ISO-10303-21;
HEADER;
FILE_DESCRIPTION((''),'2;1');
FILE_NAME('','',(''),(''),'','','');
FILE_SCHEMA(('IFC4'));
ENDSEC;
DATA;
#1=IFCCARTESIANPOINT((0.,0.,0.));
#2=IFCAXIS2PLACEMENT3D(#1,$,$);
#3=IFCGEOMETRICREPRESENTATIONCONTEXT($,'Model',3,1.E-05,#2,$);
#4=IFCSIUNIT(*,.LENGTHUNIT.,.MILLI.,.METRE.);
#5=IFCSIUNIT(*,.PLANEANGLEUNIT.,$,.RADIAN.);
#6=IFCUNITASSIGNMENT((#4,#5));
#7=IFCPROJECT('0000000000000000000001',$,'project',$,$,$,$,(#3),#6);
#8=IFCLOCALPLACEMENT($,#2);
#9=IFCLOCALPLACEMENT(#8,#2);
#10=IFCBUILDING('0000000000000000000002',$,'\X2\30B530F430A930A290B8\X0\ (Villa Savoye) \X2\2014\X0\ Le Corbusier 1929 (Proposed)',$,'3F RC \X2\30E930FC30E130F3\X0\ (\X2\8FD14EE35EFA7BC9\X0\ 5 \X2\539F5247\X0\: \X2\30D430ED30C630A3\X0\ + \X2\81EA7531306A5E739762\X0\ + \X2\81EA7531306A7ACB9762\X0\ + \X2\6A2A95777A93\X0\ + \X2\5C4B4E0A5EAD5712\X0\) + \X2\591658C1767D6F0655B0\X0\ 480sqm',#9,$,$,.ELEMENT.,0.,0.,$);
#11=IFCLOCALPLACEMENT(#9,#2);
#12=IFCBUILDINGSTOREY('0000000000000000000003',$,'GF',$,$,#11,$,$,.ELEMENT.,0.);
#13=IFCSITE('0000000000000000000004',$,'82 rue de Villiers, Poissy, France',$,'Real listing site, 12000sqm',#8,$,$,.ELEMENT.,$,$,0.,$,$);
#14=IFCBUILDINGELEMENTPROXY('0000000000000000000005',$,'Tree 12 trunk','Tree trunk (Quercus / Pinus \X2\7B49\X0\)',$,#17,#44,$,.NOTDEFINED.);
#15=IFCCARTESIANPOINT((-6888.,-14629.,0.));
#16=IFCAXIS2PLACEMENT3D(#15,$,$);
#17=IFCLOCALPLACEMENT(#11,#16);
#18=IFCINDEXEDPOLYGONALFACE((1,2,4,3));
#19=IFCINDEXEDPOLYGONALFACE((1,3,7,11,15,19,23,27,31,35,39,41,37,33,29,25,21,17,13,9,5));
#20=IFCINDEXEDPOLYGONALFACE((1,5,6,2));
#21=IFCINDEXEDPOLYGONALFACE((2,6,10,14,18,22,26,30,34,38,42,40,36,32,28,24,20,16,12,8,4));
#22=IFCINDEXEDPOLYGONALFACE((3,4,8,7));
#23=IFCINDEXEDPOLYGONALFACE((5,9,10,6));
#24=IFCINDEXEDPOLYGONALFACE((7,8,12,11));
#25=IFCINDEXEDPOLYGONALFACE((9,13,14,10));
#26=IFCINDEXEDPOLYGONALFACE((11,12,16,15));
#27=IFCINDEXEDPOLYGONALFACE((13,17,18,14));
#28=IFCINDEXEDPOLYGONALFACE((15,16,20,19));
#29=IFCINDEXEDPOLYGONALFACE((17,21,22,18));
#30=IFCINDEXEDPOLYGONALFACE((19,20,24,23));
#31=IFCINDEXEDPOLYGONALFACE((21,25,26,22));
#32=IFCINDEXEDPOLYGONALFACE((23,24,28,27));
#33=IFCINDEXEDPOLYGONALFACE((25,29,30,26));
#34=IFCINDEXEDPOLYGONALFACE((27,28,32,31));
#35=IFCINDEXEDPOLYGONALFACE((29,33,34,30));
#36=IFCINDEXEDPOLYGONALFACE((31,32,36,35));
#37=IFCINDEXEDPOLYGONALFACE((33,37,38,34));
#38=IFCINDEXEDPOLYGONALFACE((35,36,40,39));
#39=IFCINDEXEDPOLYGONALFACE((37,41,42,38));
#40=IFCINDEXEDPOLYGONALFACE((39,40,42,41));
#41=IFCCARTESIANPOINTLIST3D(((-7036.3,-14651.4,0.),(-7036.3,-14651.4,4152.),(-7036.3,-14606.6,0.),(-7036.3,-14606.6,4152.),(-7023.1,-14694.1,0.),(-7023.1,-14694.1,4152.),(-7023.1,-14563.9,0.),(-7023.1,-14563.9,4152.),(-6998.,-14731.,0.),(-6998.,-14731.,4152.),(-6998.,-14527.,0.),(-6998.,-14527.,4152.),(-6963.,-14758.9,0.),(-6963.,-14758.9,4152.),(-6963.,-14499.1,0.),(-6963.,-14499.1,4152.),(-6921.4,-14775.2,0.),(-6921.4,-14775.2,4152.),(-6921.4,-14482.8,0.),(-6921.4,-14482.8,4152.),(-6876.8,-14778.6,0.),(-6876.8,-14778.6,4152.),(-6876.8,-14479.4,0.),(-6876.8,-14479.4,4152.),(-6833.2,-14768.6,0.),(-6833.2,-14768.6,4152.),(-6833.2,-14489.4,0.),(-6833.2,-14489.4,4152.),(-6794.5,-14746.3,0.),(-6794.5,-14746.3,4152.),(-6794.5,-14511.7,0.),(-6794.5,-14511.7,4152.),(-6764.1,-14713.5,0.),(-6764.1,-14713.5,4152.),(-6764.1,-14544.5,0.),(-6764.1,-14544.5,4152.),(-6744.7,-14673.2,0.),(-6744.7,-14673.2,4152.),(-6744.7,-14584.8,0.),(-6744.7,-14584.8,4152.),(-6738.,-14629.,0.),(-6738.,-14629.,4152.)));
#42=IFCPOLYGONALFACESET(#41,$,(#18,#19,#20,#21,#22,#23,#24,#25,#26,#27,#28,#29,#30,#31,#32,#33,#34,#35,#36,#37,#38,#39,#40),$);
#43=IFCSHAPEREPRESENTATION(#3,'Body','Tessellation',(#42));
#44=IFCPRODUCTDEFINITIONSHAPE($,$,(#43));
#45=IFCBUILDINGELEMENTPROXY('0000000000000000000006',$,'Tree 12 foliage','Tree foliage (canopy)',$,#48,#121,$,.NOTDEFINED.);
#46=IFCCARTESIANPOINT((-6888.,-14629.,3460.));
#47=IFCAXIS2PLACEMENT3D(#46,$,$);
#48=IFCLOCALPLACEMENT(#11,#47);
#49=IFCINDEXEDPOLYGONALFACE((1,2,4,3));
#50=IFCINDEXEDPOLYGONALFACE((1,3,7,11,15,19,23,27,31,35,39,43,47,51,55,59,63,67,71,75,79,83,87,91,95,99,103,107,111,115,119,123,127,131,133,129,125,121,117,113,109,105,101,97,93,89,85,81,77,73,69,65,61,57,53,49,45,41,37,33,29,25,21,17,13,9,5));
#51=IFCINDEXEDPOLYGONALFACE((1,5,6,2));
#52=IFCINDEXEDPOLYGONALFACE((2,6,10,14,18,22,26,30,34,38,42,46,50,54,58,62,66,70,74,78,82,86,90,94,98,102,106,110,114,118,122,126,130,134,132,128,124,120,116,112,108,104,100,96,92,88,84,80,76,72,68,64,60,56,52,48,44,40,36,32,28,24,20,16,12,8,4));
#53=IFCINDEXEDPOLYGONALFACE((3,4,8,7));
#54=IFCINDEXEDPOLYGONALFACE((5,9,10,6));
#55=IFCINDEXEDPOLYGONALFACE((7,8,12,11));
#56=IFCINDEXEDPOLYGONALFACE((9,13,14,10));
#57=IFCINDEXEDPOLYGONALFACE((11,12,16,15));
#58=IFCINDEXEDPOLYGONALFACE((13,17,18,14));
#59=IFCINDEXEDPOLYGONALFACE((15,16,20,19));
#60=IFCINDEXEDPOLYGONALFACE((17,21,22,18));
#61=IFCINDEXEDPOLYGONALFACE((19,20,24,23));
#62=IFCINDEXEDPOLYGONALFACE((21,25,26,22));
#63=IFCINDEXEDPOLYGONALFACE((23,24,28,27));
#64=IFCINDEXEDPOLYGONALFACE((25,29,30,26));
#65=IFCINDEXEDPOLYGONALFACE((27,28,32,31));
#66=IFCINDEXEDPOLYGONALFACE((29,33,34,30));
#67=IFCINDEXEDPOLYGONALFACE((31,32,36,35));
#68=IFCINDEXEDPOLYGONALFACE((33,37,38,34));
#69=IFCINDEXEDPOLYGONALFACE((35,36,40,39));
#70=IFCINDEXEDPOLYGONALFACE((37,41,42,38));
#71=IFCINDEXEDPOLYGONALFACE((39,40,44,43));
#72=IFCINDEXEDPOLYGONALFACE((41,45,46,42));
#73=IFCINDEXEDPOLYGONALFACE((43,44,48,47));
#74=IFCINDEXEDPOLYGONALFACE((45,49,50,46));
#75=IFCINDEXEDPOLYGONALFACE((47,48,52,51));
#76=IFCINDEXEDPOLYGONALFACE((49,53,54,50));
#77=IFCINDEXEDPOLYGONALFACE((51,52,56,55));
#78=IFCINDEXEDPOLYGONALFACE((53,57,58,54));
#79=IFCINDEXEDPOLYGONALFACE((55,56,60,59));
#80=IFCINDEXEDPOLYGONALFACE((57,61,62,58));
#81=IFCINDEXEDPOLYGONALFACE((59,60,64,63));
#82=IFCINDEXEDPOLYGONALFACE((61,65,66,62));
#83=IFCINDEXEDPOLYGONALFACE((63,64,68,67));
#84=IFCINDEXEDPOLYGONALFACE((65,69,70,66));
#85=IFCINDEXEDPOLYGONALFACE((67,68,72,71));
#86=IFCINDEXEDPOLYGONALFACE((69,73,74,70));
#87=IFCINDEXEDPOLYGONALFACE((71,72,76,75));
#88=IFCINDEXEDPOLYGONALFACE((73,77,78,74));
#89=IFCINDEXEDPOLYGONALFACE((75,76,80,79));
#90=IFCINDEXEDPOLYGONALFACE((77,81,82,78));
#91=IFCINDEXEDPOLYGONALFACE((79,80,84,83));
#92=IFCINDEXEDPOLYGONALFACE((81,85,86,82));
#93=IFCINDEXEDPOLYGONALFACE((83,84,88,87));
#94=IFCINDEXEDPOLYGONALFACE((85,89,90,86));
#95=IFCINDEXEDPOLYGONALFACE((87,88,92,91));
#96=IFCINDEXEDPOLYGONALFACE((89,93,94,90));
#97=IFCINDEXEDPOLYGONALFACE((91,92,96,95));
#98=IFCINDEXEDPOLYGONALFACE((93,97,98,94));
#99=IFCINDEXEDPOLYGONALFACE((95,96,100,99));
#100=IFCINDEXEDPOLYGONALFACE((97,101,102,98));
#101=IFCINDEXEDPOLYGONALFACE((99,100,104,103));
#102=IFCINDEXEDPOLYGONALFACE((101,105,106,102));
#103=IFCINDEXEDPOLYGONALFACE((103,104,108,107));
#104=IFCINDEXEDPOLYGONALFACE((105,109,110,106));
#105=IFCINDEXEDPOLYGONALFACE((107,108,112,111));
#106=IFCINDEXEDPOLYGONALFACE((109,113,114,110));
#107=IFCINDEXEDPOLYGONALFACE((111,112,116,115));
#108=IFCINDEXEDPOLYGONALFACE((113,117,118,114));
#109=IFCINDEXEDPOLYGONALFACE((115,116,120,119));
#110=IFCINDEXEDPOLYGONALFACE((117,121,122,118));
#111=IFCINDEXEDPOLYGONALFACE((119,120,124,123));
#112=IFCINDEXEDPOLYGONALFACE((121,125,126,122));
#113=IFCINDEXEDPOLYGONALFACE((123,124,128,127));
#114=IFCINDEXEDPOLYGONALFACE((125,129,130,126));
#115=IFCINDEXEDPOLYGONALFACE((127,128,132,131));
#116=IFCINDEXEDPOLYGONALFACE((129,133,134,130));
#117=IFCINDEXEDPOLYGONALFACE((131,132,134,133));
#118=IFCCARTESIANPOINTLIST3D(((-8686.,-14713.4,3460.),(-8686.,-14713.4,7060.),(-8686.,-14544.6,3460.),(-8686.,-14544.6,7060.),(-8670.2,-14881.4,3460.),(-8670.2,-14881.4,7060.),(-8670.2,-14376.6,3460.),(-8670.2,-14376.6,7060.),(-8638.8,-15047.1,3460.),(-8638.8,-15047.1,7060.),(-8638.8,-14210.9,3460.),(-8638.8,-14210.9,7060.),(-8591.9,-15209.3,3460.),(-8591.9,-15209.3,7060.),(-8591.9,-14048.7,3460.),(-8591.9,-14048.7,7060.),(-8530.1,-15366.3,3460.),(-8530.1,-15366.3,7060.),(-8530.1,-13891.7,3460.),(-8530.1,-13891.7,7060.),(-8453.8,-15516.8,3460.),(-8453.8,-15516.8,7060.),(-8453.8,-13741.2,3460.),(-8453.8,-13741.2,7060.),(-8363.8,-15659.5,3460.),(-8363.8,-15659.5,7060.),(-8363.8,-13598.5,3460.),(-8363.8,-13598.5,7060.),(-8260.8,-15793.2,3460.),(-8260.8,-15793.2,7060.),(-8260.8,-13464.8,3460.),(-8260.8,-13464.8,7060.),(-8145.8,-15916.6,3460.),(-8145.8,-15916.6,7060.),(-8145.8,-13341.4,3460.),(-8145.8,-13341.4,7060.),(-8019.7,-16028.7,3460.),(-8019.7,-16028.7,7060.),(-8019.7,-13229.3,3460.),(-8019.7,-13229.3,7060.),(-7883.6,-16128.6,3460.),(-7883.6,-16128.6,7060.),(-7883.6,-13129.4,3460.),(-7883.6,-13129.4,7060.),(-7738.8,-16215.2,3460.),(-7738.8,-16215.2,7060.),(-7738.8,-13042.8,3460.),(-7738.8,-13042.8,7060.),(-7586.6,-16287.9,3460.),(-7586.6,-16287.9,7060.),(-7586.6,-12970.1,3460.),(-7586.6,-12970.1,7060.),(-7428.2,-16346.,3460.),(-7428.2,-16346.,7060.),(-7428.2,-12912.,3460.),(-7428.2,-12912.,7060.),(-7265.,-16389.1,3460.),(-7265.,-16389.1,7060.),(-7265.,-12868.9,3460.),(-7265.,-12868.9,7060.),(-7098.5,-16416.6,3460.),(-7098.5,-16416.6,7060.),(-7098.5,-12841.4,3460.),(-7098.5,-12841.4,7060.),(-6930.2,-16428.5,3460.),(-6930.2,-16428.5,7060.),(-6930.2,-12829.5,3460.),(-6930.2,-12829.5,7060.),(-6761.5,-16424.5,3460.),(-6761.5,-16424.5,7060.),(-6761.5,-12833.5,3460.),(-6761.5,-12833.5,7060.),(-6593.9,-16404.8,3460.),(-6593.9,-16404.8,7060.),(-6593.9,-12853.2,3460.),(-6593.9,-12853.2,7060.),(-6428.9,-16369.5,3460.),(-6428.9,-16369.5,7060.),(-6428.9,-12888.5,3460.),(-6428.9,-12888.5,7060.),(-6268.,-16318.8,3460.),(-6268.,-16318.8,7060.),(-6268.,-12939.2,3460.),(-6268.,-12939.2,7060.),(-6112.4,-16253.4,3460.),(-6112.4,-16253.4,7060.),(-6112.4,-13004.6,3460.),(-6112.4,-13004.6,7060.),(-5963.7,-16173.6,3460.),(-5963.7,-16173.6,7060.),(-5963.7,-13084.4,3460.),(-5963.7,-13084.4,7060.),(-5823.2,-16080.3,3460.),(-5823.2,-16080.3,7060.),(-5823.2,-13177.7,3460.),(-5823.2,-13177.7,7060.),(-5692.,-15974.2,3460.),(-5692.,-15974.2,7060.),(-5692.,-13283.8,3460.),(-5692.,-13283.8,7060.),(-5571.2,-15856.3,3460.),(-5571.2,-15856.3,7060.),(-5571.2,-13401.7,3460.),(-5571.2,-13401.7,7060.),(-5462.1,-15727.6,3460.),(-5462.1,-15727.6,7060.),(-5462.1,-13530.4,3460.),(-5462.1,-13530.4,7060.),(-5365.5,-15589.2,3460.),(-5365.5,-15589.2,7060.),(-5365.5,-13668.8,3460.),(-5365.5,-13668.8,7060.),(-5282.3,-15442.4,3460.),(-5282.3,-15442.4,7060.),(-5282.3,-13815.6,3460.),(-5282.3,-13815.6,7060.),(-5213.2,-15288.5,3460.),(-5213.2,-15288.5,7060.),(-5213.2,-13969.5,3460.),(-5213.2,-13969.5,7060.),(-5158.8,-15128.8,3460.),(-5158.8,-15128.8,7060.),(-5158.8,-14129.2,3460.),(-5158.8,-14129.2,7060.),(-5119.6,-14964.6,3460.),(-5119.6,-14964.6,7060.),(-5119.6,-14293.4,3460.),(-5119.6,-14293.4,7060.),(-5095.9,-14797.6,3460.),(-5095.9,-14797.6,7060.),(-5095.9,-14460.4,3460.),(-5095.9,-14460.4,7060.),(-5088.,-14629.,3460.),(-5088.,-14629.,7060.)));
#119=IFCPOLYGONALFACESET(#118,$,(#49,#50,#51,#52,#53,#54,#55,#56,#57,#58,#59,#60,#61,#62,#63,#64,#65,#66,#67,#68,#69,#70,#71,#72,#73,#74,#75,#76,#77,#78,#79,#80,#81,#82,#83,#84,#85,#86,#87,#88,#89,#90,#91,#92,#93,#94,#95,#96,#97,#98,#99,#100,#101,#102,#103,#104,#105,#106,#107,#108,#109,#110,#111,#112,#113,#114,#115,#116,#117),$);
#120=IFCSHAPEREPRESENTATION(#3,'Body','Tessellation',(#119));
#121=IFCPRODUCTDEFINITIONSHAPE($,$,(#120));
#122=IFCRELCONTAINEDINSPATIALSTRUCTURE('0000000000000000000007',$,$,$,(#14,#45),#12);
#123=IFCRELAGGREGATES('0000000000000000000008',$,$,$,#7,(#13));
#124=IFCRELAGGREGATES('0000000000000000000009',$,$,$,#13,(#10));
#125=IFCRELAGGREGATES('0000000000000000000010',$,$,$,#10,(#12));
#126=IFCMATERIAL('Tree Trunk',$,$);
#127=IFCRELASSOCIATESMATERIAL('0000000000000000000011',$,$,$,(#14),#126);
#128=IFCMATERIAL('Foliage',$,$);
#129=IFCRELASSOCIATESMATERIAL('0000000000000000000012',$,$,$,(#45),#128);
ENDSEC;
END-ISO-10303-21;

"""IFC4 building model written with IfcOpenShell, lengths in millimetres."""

from ifc_helpers import new_model, si_unit, frame, origin, origin_2d, place, context, project, spatial, circle, extrude, material, element, save


model = new_model("IFC4")

# Units and contexts
model_context = context("Model", 3, precision=1e-05, world=origin())
ifc_project = project(units=[si_unit("LENGTHUNIT", "METRE", prefix="MILLI"), si_unit("PLANEANGLEUNIT", "RADIAN")], contexts=[model_context])

# Site, building, storey
site_placement = place(None, origin())
site = spatial("IfcSite", under=ifc_project, at=site_placement, Name="82 rue de Villiers, Poissy, France", ObjectType="Real listing site, 12000sqm", CompositionType="ELEMENT", RefElevation=0.0)
building_placement = place(site_placement, origin())
building = spatial("IfcBuilding", under=site, at=building_placement, Name="サヴォア邸 (Villa Savoye) — Le Corbusier 1929 (Proposed)", ObjectType="3F RC ラーメン (近代建築 5 原則: ピロティ + 自由な平面 + 自由な立面 + 横長窓 + 屋上庭園) + 外壁白漆喰 480sqm", CompositionType="ELEMENT", ElevationOfRefHeight=0.0, ElevationOfTerrain=0.0)
storey_placement = place(building_placement, origin())
storey = spatial("IfcBuildingStorey", under=building, at=storey_placement, Name="GF", CompositionType="ELEMENT", Elevation=0.0)

# Building element proxies
ifc_material_1 = material(Name="Tree Trunk")
ifc_material_2 = material(Name="Foliage")
proxy_1_placement = place(storey_placement, frame((-6888.0, -14629.0, 0.0)))
element("IfcBuildingElementProxy", 1, at=proxy_1_placement, inside=storey, material=ifc_material_1, Name="Tree 12 trunk", Description="Tree trunk (Quercus / Pinus 等)", PredefinedType="NOTDEFINED", context=model_context, shape_type="SweptSolid", body=[
    extrude(circle(Radius=150.0, at=origin_2d()), frame((-6888.0, -14629.0, 0.0)), (0.0, 0.0, 1.0), 4152.0),
])
proxy_2_placement = place(storey_placement, frame((-6888.0, -14629.0, 3460.0)))
element("IfcBuildingElementProxy", 2, at=proxy_2_placement, inside=storey, material=ifc_material_2, Name="Tree 12 foliage", Description="Tree foliage (canopy)", PredefinedType="NOTDEFINED", context=model_context, shape_type="SweptSolid", body=[
    extrude(circle(Radius=1800.0, at=origin_2d()), frame((-6888.0, -14629.0, 3460.0)), (0.0, 0.0, 1.0), 3600.0),
])

save(model, "model.ifc")
